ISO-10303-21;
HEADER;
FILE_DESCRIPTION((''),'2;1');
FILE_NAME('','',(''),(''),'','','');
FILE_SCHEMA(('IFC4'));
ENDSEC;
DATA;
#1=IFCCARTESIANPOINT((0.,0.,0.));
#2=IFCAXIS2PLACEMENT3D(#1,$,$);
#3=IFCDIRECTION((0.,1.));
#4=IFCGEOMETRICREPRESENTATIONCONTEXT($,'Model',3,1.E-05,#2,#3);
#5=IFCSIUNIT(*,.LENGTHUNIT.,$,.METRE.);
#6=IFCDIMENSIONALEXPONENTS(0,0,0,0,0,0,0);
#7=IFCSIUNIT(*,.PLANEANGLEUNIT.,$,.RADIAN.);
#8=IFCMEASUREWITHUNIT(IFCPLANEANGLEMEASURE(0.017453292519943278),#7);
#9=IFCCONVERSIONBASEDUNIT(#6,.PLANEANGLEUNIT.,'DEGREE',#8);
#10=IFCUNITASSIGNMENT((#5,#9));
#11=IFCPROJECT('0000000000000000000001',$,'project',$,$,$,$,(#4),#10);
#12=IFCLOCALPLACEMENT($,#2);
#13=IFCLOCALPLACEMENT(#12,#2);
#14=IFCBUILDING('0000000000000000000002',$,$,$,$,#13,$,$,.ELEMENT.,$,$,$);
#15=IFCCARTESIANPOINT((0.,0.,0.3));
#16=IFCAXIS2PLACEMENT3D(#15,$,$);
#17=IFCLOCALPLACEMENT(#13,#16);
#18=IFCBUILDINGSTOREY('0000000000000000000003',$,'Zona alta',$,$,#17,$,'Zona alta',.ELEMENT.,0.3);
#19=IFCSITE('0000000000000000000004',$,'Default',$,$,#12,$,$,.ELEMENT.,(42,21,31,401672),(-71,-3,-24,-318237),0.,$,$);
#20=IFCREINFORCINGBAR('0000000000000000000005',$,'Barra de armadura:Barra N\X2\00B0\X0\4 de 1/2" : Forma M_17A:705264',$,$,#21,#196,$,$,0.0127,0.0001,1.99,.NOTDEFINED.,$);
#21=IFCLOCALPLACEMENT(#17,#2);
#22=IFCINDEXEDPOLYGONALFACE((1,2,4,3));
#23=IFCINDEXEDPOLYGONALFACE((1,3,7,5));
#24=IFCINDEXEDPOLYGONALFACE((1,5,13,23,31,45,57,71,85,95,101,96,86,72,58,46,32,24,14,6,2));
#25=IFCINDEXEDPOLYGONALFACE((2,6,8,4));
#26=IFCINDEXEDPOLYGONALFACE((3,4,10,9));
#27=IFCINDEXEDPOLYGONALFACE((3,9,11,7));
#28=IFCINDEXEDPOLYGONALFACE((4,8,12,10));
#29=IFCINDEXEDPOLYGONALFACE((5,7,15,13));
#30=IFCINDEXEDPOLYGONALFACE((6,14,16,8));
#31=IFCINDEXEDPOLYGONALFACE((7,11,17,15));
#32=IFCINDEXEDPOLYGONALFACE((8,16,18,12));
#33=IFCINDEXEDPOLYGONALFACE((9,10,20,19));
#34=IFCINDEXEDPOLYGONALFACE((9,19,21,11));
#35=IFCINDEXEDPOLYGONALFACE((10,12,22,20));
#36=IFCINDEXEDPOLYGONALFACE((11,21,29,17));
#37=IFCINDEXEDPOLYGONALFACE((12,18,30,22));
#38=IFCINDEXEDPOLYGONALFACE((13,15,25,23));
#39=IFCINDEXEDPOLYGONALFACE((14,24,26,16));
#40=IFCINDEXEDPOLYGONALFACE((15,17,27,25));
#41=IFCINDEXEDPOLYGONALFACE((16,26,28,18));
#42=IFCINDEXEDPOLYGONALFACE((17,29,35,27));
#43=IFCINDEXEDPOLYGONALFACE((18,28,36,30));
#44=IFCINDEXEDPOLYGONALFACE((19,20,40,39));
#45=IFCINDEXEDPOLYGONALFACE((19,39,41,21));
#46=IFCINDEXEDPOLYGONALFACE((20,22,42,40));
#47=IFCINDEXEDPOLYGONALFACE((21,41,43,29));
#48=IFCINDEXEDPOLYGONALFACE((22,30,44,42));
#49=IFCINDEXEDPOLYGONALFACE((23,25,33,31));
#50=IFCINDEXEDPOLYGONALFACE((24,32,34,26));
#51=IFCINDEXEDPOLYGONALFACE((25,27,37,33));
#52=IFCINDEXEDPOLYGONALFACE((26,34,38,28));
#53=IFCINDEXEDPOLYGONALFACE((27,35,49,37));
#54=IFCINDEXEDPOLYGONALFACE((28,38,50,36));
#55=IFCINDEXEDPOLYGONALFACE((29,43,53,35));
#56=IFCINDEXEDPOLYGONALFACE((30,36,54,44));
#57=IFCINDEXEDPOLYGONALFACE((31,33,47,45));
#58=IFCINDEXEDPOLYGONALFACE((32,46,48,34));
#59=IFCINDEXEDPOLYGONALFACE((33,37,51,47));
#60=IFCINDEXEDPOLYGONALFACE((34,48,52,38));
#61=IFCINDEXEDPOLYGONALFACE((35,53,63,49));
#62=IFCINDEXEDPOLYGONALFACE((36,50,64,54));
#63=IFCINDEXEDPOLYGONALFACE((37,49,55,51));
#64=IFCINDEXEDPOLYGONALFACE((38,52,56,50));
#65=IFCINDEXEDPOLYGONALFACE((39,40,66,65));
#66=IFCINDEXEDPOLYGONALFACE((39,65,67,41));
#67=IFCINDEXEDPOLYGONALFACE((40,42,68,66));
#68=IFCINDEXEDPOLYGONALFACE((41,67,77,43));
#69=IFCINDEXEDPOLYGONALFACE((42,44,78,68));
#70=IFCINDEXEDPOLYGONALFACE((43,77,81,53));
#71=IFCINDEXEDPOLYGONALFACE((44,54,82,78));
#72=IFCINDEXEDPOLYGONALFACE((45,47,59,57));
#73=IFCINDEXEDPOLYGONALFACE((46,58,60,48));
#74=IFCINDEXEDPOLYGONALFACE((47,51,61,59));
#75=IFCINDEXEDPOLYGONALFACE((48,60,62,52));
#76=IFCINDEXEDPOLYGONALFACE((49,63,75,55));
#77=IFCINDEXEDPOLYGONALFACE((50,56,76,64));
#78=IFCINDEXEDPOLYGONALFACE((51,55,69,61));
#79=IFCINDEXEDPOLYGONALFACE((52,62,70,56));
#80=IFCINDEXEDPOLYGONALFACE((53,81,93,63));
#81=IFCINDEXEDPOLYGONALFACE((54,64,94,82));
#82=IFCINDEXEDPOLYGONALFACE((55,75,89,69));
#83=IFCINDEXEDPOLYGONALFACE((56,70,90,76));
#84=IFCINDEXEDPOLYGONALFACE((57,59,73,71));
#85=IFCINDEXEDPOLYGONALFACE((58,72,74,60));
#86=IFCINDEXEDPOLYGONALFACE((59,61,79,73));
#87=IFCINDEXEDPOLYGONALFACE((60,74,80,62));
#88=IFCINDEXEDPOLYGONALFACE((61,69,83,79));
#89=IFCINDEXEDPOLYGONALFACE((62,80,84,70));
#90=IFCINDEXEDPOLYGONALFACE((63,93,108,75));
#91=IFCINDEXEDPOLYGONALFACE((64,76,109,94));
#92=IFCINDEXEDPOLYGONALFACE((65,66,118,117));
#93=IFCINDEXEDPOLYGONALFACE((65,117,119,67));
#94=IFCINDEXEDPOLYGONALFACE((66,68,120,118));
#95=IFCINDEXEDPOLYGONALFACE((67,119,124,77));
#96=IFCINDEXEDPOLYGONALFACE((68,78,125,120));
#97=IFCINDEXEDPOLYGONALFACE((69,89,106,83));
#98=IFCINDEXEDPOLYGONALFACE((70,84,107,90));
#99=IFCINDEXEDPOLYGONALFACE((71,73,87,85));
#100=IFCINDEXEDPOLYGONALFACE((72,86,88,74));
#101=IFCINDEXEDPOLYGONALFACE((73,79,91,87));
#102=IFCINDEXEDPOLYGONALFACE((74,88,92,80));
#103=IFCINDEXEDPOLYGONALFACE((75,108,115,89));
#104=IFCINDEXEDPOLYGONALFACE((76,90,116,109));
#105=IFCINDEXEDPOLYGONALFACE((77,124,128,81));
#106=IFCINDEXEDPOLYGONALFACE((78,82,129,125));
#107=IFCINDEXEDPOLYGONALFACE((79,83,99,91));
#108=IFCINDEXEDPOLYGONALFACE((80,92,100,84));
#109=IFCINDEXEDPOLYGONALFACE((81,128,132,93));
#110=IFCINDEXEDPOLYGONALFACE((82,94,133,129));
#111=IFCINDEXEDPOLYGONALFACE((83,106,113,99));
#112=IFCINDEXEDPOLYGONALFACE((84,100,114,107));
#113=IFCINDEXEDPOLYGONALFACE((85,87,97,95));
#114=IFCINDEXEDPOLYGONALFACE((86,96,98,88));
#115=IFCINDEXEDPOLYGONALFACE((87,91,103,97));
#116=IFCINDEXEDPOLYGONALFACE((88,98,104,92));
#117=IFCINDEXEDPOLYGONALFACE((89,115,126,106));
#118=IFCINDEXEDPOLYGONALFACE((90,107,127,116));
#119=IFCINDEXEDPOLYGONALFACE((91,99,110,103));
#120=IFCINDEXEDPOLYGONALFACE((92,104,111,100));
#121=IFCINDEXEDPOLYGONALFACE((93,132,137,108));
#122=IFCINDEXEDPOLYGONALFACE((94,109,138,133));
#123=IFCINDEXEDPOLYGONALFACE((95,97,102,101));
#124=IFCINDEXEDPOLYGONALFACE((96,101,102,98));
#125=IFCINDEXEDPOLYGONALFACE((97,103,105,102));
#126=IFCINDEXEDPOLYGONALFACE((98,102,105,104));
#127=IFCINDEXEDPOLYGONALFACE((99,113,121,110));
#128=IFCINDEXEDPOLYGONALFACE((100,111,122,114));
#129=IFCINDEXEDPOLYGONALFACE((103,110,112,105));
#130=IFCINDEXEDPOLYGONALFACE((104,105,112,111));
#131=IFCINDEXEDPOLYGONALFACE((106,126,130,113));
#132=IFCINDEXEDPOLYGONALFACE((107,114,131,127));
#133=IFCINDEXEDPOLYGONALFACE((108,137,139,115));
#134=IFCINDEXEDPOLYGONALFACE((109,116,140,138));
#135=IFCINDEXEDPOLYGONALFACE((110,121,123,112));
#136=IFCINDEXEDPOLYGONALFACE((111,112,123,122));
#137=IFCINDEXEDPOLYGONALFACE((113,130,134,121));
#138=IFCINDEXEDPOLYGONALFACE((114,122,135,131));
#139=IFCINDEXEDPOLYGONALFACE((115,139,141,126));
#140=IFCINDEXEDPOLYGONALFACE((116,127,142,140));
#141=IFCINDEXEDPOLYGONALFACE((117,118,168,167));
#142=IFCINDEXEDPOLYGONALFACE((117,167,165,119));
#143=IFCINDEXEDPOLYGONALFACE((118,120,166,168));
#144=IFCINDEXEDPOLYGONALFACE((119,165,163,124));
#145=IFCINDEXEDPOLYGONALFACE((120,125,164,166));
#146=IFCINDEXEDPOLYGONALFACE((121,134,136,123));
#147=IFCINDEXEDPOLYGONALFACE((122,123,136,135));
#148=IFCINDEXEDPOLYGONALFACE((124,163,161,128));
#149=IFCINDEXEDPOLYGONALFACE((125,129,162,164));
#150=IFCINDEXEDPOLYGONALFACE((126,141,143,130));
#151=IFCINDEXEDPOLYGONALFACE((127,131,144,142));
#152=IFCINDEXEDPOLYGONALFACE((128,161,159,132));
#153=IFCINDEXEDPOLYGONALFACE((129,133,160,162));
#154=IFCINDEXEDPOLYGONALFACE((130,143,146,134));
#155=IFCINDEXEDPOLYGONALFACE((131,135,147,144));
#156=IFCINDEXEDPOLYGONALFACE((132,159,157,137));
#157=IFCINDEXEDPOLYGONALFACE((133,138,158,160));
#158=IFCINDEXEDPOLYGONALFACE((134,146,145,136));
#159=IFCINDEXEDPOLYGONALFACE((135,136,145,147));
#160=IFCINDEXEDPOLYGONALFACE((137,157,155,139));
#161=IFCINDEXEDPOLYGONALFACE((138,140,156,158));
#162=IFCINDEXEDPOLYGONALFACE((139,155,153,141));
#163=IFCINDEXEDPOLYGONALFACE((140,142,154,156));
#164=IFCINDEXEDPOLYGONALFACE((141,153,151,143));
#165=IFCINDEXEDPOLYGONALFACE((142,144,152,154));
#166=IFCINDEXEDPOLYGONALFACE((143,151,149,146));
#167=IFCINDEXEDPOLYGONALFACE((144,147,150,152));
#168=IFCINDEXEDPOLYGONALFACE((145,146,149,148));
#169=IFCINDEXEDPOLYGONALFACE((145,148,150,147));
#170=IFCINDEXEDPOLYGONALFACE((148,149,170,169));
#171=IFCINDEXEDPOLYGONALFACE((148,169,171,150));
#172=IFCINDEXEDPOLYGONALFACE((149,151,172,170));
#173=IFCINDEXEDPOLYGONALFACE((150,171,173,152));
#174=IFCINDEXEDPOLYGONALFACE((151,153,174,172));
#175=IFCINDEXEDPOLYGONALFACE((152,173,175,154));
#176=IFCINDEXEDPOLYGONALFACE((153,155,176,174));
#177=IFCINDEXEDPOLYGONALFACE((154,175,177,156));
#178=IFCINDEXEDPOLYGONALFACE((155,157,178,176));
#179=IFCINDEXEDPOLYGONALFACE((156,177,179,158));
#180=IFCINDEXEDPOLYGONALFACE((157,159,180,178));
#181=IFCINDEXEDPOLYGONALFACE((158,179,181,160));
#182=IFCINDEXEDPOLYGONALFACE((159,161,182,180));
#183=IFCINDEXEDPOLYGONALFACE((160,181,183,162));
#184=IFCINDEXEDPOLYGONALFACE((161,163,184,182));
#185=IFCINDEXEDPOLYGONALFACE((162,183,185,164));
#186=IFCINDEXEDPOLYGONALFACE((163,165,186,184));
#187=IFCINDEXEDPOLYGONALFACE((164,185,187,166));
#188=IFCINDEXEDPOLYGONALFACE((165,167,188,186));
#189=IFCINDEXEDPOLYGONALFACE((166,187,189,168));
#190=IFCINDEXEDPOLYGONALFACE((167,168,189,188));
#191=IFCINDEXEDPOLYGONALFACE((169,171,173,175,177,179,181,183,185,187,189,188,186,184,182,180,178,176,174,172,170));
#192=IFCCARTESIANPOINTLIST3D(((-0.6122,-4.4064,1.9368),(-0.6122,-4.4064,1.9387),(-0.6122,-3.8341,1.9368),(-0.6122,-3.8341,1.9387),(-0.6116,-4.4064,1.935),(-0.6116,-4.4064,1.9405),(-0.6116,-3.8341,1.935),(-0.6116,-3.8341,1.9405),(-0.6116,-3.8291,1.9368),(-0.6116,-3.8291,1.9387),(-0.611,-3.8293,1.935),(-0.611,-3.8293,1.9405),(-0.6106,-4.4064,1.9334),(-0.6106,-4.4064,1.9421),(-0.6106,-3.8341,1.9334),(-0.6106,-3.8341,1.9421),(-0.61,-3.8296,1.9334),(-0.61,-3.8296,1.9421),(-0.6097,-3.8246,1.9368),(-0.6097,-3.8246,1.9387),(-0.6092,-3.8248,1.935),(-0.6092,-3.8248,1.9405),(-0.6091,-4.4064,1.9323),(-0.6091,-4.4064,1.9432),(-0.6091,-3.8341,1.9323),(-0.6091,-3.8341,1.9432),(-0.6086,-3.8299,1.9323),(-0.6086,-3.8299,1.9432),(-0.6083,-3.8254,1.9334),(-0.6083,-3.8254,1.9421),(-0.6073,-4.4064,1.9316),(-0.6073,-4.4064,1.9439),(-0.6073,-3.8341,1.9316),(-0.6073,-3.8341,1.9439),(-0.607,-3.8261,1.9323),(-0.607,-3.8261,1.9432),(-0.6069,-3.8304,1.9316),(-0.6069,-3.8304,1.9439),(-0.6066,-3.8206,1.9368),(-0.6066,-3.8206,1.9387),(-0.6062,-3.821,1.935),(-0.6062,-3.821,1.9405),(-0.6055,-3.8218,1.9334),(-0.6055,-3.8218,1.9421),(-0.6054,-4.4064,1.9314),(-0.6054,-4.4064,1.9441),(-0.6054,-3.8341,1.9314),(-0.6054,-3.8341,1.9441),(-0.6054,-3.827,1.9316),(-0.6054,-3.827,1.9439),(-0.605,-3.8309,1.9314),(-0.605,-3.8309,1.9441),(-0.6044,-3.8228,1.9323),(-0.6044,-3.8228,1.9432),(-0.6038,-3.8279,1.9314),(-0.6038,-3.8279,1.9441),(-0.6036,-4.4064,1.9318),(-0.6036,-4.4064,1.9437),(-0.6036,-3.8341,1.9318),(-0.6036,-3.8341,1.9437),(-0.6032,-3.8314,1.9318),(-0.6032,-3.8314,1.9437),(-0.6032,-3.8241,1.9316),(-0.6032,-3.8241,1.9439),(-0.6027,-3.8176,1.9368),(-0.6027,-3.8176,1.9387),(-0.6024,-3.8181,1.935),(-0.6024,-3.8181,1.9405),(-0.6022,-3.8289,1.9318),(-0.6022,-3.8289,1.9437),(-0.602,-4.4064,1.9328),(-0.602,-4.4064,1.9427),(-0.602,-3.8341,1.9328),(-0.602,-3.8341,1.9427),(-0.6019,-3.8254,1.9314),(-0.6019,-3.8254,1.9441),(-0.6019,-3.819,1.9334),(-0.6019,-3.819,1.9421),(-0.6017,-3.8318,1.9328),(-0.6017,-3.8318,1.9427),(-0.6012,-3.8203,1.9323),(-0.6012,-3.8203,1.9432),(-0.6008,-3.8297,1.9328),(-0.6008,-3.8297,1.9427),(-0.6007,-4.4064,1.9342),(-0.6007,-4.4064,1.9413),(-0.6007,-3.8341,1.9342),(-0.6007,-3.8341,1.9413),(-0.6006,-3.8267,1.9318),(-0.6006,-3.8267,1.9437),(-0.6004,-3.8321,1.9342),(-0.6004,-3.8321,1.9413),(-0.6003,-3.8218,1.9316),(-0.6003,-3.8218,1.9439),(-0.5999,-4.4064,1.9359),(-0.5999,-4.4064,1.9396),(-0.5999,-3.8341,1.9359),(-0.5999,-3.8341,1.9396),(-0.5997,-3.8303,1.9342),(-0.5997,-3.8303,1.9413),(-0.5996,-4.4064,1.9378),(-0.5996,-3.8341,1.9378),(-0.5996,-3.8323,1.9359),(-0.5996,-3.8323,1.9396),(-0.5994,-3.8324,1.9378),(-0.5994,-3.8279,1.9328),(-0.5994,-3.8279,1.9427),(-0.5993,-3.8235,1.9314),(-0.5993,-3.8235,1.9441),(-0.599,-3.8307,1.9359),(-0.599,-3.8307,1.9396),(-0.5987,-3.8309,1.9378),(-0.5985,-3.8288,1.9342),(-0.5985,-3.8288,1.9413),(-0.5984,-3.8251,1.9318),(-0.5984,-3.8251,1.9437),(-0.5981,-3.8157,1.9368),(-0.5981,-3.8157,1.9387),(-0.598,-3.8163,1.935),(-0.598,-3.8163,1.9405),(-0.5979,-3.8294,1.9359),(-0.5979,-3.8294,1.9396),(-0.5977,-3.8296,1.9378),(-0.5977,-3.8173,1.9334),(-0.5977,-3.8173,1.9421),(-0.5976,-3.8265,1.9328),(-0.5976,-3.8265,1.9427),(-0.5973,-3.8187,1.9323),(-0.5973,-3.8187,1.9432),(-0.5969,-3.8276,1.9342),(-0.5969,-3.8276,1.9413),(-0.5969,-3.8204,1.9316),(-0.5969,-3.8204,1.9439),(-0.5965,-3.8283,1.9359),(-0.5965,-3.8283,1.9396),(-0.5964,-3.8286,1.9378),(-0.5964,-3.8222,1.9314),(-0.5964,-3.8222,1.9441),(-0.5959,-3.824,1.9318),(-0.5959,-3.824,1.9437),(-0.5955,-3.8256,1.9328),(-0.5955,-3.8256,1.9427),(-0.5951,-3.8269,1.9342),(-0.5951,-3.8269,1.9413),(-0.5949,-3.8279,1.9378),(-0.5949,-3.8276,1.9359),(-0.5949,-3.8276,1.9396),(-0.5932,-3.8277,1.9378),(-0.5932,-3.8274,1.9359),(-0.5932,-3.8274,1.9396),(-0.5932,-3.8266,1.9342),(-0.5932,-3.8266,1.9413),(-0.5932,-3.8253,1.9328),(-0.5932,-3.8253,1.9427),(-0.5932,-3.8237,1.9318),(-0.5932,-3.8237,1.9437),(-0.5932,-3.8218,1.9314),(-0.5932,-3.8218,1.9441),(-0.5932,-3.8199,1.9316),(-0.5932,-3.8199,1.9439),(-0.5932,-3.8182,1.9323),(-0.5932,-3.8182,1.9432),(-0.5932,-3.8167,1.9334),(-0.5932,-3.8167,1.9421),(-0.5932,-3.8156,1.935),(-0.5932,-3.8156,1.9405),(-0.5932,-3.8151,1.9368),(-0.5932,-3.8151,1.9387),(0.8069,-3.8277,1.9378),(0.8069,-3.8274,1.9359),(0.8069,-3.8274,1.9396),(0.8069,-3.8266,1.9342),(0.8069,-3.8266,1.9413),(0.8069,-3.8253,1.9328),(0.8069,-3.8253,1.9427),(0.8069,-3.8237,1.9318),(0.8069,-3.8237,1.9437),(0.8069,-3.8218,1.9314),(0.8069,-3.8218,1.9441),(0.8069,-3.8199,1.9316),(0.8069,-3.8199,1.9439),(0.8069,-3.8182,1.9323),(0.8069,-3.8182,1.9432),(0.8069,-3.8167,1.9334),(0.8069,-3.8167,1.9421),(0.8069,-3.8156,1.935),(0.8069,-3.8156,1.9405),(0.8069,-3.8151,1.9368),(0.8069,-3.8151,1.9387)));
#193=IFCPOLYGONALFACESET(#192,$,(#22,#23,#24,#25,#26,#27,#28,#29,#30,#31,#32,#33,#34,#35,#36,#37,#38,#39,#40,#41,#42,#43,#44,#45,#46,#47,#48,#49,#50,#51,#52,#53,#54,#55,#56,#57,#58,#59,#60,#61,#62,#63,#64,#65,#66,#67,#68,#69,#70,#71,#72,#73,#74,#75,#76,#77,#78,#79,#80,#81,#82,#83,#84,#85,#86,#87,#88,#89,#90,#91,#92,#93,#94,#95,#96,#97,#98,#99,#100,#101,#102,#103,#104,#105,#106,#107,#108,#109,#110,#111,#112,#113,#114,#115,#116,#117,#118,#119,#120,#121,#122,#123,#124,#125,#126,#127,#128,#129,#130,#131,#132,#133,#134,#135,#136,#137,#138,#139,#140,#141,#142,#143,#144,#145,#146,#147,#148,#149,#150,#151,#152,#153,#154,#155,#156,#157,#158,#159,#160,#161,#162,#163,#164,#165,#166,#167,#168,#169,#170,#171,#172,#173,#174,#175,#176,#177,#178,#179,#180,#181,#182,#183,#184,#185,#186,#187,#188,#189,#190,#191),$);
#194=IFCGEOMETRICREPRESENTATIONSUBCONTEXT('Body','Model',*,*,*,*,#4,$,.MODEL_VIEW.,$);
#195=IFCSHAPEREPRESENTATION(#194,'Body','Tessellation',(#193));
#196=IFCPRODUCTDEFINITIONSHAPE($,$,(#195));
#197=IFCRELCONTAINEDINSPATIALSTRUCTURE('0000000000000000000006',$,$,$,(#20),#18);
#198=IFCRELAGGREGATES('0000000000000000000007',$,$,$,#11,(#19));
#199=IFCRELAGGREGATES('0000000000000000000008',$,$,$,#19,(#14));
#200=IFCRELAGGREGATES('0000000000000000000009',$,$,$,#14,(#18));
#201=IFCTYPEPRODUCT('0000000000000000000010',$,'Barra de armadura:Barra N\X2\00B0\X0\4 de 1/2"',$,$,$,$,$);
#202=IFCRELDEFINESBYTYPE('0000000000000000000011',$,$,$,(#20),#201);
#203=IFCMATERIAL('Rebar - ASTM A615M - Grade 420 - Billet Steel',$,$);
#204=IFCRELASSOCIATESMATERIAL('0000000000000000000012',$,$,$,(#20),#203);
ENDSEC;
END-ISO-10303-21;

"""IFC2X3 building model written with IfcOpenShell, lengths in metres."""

from ifc_helpers import new_model, entity, si_unit, converted_unit, direction, frame, origin, place, context, subcontext, project, spatial, material, type_object, element, save


model = new_model("IFC2X3")

# Units and contexts
model_context = context("Model", 3, precision=1e-05, world=origin(), true_north=direction((0.0, 1.0)))
body_context = subcontext(model_context, "Body", "Model", "MODEL_VIEW")
ifc_project = project(units=[si_unit("LENGTHUNIT", "METRE"), converted_unit("PLANEANGLEUNIT", "DEGREE", entity("IfcPlaneAngleMeasure", 0.017453292519943278), si_unit("PLANEANGLEUNIT", "RADIAN"), dimensions=[0, 0, 0, 0, 0, 0, 0])], contexts=[model_context])

# Site, building, storey
site_placement = place(None, origin())
site = spatial("IfcSite", under=ifc_project, at=site_placement, Name="Default", CompositionType="ELEMENT", RefLatitude=(42, 21, 31, 401672), RefLongitude=(-71, -3, -24, -318237), RefElevation=0.0)
building_placement = place(site_placement, origin())
building = spatial("IfcBuilding", under=site, at=building_placement, CompositionType="ELEMENT")
storey_placement = place(building_placement, frame((0.0, 0.0, 0.3)))
storey = spatial("IfcBuildingStorey", under=building, at=storey_placement, Name="Zona alta", LongName="Zona alta", CompositionType="ELEMENT", Elevation=0.3)

# Reinforcing bar
ifc_material = material(Name="Rebar - ASTM A615M - Grade 420 - Billet Steel")
type_product_1 = type_object("IfcTypeProduct", Name="Barra de armadura:Barra N°4 de 1/2\"")
reinforcing_bar_1_placement = place(storey_placement, origin())
element("IfcReinforcingBar", 1, at=reinforcing_bar_1_placement, inside=storey, type_object=type_product_1, material=ifc_material, Name="Barra de armadura:Barra N°4 de 1/2\" : Forma M_17A:705264", BarLength=1.99, BarRole="NOTDEFINED", CrossSectionArea=0.0001, NominalDiameter=0.0127, context=body_context, shape_type="AdvancedSweptSolid", body=[
    entity("IfcSweptDiskSolid", entity("IfcCompositeCurve", [entity("IfcCompositeCurveSegment", "CONTINUOUS", True, entity("IfcPolyline", [entity("IfcCartesianPoint", [0.8069, -3.8214, 1.9378]), entity("IfcCartesianPoint", [-0.5932, -3.8214, 1.9378])])), entity("IfcCompositeCurveSegment", "CONTINUOUS", True, entity("IfcTrimmedCurve", entity("IfcCircle", entity("IfcAxis2Placement3D", entity("IfcCartesianPoint", [-0.5932, -3.8341, 1.9378]), entity("IfcDirection", [0.0, 0.0, 1.0]), entity("IfcDirection", [-1.0, 0.0, 0.0])), 0.0127), [entity("IfcParameterValue", 270.0)], [entity("IfcParameterValue", 360.0)], True, "PARAMETER")), entity("IfcCompositeCurveSegment", "CONTINUOUS", True, entity("IfcPolyline", [entity("IfcCartesianPoint", [-0.6059, -3.8341, 1.9378]), entity("IfcCartesianPoint", [-0.6059, -4.4064, 1.9378])]))], False), 0.0063, None, 0.0, 92.0),
])

save(model, "model.ifc")
